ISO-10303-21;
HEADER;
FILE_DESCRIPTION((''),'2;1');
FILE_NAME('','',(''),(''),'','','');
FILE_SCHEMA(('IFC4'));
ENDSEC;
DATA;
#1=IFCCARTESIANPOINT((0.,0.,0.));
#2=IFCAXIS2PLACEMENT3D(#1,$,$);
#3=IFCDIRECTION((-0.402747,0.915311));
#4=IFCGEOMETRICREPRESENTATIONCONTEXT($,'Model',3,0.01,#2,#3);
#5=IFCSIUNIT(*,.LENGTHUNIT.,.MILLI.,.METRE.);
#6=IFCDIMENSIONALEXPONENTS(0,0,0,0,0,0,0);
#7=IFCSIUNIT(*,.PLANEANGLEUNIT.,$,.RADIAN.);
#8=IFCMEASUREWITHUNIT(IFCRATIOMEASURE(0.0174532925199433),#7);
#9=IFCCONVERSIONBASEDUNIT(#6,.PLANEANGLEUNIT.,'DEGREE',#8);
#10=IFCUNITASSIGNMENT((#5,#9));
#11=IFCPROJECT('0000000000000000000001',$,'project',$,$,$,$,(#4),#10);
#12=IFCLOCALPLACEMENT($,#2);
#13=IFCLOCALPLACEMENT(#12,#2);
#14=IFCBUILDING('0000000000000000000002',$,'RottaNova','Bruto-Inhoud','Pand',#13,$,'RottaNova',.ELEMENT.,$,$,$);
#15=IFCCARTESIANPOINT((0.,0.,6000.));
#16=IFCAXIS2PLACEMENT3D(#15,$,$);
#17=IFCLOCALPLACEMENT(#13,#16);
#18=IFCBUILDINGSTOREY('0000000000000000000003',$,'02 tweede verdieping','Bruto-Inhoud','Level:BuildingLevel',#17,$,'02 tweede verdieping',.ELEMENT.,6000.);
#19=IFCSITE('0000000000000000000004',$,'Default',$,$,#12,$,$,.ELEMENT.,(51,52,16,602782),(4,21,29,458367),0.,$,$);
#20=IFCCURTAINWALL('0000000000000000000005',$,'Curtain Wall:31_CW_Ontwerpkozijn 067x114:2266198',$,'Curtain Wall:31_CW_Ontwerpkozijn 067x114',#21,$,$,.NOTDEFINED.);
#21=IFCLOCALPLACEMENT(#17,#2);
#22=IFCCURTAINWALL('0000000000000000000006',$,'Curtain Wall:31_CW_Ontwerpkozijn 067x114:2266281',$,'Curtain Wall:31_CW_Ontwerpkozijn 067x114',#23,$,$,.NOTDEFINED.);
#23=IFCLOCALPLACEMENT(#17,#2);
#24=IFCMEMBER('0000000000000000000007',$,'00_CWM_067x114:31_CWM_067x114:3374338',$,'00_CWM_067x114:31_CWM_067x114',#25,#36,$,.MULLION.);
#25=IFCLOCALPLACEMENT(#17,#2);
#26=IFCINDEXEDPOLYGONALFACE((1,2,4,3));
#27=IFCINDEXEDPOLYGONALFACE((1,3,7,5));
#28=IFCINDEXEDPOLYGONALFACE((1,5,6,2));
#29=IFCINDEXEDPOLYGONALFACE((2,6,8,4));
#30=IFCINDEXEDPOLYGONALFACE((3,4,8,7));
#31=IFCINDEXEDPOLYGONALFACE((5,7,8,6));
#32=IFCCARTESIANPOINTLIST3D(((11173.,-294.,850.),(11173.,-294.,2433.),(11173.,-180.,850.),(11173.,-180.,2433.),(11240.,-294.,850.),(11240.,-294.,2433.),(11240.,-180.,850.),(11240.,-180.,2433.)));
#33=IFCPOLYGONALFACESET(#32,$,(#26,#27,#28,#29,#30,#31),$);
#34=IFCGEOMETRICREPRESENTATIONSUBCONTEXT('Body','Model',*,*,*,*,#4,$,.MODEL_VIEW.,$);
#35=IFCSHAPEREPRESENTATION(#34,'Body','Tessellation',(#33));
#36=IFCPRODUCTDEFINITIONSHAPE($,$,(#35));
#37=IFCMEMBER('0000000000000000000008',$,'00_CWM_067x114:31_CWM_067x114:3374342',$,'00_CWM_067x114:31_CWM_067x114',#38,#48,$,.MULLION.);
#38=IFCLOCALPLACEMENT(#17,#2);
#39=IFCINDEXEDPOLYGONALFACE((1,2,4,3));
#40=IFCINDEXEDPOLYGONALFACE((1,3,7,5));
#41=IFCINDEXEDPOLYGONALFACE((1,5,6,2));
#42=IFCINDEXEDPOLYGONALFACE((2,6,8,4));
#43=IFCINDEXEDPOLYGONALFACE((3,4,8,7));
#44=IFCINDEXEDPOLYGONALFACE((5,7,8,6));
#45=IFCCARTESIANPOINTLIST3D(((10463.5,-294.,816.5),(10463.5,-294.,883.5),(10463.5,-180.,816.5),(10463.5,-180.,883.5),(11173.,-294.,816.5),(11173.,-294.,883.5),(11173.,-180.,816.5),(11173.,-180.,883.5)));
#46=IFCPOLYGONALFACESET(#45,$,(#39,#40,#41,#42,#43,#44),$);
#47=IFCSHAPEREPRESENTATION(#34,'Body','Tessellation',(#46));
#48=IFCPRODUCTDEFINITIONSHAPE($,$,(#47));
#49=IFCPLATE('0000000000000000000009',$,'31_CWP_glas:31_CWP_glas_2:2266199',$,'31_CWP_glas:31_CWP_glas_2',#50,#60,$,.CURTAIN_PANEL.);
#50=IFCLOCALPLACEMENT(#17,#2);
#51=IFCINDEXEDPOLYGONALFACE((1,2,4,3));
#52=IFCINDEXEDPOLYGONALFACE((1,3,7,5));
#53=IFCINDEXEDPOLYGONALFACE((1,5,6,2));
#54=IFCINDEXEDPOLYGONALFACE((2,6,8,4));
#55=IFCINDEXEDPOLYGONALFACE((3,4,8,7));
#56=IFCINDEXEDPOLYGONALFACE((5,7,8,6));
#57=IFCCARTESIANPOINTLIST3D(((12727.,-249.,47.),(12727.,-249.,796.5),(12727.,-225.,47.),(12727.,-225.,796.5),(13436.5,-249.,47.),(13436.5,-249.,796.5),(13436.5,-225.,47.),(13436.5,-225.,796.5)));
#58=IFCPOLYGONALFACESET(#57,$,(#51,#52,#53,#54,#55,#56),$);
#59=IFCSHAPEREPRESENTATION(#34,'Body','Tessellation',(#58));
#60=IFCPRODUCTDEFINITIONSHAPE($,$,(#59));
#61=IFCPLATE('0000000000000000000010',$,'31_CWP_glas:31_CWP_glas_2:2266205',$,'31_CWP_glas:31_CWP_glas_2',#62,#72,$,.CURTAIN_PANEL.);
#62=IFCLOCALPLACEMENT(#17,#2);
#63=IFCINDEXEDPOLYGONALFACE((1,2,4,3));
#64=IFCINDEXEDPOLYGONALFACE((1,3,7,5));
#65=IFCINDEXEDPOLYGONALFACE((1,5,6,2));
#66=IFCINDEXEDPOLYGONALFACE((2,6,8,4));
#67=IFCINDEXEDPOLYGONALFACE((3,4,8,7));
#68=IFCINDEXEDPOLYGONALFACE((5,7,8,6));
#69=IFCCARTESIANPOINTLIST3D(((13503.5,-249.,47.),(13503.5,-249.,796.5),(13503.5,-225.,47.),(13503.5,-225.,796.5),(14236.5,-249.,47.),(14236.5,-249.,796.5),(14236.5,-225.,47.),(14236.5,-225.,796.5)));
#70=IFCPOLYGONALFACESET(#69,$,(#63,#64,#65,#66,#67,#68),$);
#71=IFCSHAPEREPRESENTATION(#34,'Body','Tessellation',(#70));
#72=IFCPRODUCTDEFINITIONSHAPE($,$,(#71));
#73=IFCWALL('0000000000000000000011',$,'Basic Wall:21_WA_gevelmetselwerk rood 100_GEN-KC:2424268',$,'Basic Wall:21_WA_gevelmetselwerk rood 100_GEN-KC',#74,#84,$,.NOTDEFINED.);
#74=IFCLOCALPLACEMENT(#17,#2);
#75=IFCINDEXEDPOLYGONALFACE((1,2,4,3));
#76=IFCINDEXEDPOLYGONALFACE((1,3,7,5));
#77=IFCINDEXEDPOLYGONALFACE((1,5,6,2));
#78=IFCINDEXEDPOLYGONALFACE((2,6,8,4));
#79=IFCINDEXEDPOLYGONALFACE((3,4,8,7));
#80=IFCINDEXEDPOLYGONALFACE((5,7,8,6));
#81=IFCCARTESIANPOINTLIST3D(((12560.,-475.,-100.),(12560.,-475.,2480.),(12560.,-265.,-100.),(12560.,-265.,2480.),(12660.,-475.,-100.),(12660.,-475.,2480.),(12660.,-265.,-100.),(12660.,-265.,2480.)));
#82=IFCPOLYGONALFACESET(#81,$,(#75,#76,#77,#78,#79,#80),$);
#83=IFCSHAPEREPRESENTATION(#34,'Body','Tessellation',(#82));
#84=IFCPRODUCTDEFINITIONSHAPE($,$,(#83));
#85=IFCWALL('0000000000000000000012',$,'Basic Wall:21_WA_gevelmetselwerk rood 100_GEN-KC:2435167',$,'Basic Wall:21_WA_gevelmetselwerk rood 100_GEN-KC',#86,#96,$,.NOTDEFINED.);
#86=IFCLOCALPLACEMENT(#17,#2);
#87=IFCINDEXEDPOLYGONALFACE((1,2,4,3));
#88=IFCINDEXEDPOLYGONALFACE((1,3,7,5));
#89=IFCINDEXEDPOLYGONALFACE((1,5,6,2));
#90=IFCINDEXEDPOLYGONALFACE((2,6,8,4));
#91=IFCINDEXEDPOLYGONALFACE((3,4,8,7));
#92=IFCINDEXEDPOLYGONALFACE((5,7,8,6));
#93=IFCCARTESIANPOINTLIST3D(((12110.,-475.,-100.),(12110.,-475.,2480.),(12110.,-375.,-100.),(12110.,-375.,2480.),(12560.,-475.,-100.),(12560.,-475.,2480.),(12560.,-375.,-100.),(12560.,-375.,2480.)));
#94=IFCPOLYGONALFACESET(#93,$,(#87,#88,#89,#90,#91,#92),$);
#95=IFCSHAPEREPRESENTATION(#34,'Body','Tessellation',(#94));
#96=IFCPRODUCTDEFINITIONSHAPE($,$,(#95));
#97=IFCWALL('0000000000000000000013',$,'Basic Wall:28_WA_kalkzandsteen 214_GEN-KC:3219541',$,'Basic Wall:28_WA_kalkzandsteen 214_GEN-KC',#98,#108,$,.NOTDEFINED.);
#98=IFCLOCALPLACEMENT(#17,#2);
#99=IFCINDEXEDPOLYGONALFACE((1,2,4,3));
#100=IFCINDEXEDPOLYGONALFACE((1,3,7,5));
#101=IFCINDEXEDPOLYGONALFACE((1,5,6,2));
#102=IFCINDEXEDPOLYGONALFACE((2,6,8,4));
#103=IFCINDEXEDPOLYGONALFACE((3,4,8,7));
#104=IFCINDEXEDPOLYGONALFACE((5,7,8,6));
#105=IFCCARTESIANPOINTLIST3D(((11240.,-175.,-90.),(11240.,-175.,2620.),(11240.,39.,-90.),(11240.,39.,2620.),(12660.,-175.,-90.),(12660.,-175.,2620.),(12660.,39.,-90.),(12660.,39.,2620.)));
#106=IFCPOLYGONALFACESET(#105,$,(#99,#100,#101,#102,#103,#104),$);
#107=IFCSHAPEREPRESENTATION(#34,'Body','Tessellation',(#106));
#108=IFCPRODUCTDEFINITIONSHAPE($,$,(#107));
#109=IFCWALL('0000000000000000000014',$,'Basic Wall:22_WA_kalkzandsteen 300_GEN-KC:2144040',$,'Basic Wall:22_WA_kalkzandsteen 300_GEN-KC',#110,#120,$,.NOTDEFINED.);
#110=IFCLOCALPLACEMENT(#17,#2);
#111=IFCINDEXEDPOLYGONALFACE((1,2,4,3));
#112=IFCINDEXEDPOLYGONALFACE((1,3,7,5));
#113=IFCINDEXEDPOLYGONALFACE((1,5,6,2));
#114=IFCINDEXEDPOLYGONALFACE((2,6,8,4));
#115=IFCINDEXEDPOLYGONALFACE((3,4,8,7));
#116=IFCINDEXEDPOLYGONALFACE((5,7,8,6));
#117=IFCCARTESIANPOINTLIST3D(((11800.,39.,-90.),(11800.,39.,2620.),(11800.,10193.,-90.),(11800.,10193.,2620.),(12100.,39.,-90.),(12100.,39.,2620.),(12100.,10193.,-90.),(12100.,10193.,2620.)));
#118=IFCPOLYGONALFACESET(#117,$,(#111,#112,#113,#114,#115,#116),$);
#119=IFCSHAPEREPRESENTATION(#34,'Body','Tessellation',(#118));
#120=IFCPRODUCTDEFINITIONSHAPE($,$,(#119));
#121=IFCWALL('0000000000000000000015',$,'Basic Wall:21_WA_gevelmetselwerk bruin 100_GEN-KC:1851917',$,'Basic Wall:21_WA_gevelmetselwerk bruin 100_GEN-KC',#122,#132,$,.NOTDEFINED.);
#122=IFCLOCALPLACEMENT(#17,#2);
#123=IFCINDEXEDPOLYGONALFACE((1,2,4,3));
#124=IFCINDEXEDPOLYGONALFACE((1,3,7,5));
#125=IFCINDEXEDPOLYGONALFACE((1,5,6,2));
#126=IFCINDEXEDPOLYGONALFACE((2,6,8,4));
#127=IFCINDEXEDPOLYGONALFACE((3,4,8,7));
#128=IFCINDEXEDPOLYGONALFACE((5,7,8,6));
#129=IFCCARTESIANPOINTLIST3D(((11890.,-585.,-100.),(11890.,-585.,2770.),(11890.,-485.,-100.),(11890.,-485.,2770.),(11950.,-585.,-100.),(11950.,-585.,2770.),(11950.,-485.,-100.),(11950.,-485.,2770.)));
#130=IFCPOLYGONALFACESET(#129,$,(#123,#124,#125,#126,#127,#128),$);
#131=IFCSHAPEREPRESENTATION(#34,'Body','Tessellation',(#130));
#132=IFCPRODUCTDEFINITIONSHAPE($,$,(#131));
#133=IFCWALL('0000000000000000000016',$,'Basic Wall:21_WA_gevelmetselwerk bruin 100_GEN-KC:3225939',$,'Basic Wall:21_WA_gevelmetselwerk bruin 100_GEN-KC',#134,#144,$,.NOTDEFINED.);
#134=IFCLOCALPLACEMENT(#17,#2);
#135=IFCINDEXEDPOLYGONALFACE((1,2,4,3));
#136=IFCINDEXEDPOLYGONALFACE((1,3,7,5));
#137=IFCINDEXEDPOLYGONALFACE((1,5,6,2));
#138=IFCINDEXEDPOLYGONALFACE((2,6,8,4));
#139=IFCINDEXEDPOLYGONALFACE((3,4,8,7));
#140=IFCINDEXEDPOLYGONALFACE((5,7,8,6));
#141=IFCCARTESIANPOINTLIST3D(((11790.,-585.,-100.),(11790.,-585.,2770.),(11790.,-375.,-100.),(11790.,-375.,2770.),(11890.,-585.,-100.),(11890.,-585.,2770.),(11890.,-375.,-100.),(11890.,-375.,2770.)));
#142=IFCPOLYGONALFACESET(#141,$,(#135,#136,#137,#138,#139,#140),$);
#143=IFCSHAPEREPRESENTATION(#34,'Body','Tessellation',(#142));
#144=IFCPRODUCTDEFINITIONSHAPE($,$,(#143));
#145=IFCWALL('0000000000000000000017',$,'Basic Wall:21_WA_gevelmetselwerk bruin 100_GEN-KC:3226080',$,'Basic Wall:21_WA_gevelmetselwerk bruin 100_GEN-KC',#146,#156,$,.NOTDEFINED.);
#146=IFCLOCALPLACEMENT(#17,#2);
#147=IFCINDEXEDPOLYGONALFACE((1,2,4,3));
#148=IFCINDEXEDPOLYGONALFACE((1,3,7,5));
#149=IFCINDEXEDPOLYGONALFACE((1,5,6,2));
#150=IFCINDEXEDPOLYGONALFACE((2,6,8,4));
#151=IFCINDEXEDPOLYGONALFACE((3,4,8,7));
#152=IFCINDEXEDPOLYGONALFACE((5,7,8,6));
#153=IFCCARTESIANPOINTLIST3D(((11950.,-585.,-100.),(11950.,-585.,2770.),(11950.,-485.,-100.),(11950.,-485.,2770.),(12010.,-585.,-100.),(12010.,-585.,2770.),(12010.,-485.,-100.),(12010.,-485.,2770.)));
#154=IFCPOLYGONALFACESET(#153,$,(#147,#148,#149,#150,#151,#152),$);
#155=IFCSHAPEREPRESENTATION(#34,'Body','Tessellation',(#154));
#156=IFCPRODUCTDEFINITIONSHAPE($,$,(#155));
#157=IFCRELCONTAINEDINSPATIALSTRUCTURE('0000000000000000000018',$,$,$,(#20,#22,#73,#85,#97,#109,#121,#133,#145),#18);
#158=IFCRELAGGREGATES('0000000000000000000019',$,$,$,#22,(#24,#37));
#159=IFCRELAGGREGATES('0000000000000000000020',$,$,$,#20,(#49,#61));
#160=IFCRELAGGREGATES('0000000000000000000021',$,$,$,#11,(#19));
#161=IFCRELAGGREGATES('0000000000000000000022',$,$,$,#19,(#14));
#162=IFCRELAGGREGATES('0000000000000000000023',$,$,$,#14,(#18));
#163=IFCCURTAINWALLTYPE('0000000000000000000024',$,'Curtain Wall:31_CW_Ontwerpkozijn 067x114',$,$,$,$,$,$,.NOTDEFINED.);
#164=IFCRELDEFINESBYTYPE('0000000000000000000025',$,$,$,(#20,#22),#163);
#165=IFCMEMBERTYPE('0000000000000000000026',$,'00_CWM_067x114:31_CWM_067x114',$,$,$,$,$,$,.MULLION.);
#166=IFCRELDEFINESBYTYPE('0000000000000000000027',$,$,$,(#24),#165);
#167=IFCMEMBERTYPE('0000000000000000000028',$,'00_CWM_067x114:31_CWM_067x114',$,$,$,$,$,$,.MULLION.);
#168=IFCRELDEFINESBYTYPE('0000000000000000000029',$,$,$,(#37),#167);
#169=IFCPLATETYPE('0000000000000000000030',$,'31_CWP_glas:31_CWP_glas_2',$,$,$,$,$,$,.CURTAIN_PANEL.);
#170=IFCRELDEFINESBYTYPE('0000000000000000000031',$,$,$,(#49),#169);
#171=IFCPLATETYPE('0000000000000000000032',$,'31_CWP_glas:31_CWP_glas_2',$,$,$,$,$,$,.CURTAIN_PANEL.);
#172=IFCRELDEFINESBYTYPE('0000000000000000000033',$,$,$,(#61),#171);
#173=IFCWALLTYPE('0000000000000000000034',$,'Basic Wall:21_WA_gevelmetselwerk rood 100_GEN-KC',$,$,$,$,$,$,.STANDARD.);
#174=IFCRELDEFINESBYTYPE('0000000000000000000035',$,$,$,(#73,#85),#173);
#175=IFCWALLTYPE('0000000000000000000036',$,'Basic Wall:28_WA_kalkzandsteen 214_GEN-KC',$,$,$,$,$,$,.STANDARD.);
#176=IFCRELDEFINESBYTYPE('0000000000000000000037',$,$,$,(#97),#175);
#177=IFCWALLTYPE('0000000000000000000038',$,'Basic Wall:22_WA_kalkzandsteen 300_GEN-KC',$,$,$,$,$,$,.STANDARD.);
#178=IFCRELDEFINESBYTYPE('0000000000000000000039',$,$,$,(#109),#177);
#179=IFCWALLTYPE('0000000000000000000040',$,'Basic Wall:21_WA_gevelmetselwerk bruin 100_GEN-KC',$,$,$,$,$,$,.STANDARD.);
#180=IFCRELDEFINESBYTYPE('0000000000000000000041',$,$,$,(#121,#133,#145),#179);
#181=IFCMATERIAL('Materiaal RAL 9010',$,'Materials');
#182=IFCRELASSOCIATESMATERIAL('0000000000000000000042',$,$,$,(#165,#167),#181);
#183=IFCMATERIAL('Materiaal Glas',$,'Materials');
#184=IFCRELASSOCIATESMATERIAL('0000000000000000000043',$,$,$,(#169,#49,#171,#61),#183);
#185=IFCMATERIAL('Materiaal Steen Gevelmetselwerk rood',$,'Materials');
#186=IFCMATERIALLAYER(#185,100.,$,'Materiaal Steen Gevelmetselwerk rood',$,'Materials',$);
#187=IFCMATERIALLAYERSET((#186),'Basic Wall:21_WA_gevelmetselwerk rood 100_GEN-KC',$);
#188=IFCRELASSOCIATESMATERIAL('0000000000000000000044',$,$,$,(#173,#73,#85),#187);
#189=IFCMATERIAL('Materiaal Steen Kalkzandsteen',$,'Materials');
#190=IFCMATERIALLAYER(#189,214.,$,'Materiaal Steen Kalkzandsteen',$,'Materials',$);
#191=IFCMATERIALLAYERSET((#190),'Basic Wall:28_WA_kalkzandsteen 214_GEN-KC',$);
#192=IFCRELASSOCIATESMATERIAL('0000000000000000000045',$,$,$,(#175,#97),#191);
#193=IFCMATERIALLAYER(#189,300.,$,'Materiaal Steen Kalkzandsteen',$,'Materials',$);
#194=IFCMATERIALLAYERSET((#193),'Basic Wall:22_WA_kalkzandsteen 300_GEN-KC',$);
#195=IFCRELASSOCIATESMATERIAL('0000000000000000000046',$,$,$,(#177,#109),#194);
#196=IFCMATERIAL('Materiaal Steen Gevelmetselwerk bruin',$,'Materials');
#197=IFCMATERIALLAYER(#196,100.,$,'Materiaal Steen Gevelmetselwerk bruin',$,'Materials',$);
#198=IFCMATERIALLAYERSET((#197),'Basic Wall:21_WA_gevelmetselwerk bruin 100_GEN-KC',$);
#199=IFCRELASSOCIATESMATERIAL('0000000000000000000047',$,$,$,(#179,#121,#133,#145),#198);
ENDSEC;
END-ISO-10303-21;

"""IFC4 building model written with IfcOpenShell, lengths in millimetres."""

from ifc_helpers import new_model, entity, si_unit, converted_unit, direction, frame, frame_2d, origin, origin_2d_with_axis, place, context, subcontext, project, spatial, rectangle, extrude, source, transform, mapped, material, layer, layer_set, material_profile, profile_set, type_object, type_shapes, element, aggregate, save


model = new_model("IFC4")

# Units and contexts
model_context = context("Model", 3, precision=0.01, world=origin(), true_north=direction((-0.402747, 0.915311)))
body_context = subcontext(model_context, "Body", "Model", "MODEL_VIEW")
ifc_project = project(units=[si_unit("LENGTHUNIT", "METRE", prefix="MILLI"), converted_unit("PLANEANGLEUNIT", "DEGREE", entity("IfcRatioMeasure", 0.0174532925199433), si_unit("PLANEANGLEUNIT", "RADIAN"), dimensions=[0, 0, 0, 0, 0, 0, 0])], contexts=[model_context])

# Site, building, storey
site_placement = place(None, origin())
site = spatial("IfcSite", under=ifc_project, at=site_placement, Name="Default", CompositionType="ELEMENT", RefLatitude=(51, 52, 16, 602782), RefLongitude=(4, 21, 29, 458367), RefElevation=0.0)
building_placement = place(site_placement, origin())
building = spatial("IfcBuilding", under=site, at=building_placement, Name="RottaNova", Description="Bruto-Inhoud", ObjectType="Pand", LongName="RottaNova", CompositionType="ELEMENT")
storey_placement = place(building_placement, frame((0.0, 0.0, 6000.0)))
storey = spatial("IfcBuildingStorey", under=building, at=storey_placement, Name="02 tweede verdieping", Description="Bruto-Inhoud", ObjectType="Level:BuildingLevel", LongName="02 tweede verdieping", CompositionType="ELEMENT", Elevation=6000.0)

# Curtain walls, members
curtain_wall_type = type_object("IfcCurtainWallType", Name="Curtain Wall:31_CW_Ontwerpkozijn 067x114", PredefinedType="NOTDEFINED")
curtain_wall_1_placement = place(storey_placement, frame((0.0, 0.0, -6000.0)))
curtain_wall_1 = element("IfcCurtainWall", 1, at=curtain_wall_1_placement, inside=storey, type_object=curtain_wall_type, Name="Curtain Wall:31_CW_Ontwerpkozijn 067x114:2266198", ObjectType="Curtain Wall:31_CW_Ontwerpkozijn 067x114", PredefinedType="NOTDEFINED")
curtain_wall_2_placement = place(storey_placement, frame((0.0, 0.0, -6000.0)))
curtain_wall_2 = element("IfcCurtainWall", 2, at=curtain_wall_2_placement, inside=storey, type_object=curtain_wall_type, Name="Curtain Wall:31_CW_Ontwerpkozijn 067x114:2266281", ObjectType="Curtain Wall:31_CW_Ontwerpkozijn 067x114", PredefinedType="NOTDEFINED")
ifc_material_1 = material(Name="Materiaal RAL 9010", Category="Materials")
ifc_material_profile_1 = material_profile(ifc_material_1, rectangle(XDim=114.0, YDim=67.0, at=origin_2d_with_axis()), Name="31_CWM_067x114")
ifc_profile_set_1 = profile_set([ifc_material_profile_1], Name="31_CWM_067x114")
member_type_1 = type_object("IfcMemberType", Name="00_CWM_067x114:31_CWM_067x114", PredefinedType="MULLION", material=ifc_profile_set_1)
shared_shape_1 = source(origin(), body_context, "Body", "SweptSolid", [
    extrude(rectangle(XDim=114.0, YDim=67.0, at=origin_2d_with_axis()), frame((-33.5, 57.0, -1583.0), z_axis=(0.0, 0.0, 1.0), x_axis=(0.0, -1.0, 0.0)), (0.0, 0.0, 1.0), 1583.0),
])
type_shapes(member_type_1, [shared_shape_1])
member_1_placement = place(curtain_wall_2_placement, frame((11240.0, -180.0, 6850.0), z_axis=(0.0, 0.0, -1.0), x_axis=(1.0, 0.0, 0.0)))
member_1 = element("IfcMember", 3, at=member_1_placement, type_object=member_type_1, Name="00_CWM_067x114:31_CWM_067x114:3374338", ObjectType="00_CWM_067x114:31_CWM_067x114", PredefinedType="MULLION", context=body_context, shape_type="MappedRepresentation", body=[
    mapped(shared_shape_1, transform((0.0, 0.0, 0.0), scale=1.0)),
])
member_type_2 = type_object("IfcMemberType", Name="00_CWM_067x114:31_CWM_067x114", PredefinedType="MULLION", material=ifc_profile_set_1)
shared_shape_2 = source(origin(), body_context, "Body", "SweptSolid", [
    extrude(rectangle(XDim=114.0, YDim=67.0, at=origin_2d_with_axis()), frame((0.0, 57.0, -709.5), z_axis=(0.0, 0.0, 1.0), x_axis=(0.0, -1.0, 0.0)), (0.0, 0.0, 1.0), 709.5),
])
type_shapes(member_type_2, [shared_shape_2])
member_2_placement = place(curtain_wall_2_placement, frame((11173.0, -180.0, 6850.0), z_axis=(1.0, 0.0, 0.0), x_axis=(0.0, 0.0, 1.0)))
member_2 = element("IfcMember", 4, at=member_2_placement, type_object=member_type_2, Name="00_CWM_067x114:31_CWM_067x114:3374342", ObjectType="00_CWM_067x114:31_CWM_067x114", PredefinedType="MULLION", context=body_context, shape_type="MappedRepresentation", body=[
    mapped(shared_shape_2, transform((0.0, 0.0, 0.0), scale=1.0)),
])
aggregate(curtain_wall_2, [member_1, member_2])

# Plates
ifc_material_2 = material(Name="Materiaal Glas", Category="Materials")
plate_type_1 = type_object("IfcPlateType", Name="31_CWP_glas:31_CWP_glas_2", PredefinedType="CURTAIN_PANEL", material=ifc_material_2)
shared_shape_3 = source(origin(), body_context, "Body", "SweptSolid", [
    extrude(rectangle(XDim=24.0, YDim=709.5, at=frame_2d((0.0, 0.0), x_axis=(1.0, 0.0))), frame((354.8, 12.0, 0.0), z_axis=(0.0, 0.0, 1.0), x_axis=(0.0, 1.0, 0.0)), (0.0, 0.0, 1.0), 749.5),
])
type_shapes(plate_type_1, [shared_shape_3])
plate_1_placement = place(curtain_wall_1_placement, frame((12727.0, -249.0, 6047.0)))
plate_1 = element("IfcPlate", 5, at=plate_1_placement, type_object=plate_type_1, material=ifc_material_2, Name="31_CWP_glas:31_CWP_glas_2:2266199", ObjectType="31_CWP_glas:31_CWP_glas_2", PredefinedType="CURTAIN_PANEL", context=body_context, shape_type="MappedRepresentation", body=[
    mapped(shared_shape_3, transform((0.0, 0.0, 0.0), scale=1.0)),
])
plate_type_2 = type_object("IfcPlateType", Name="31_CWP_glas:31_CWP_glas_2", PredefinedType="CURTAIN_PANEL", material=ifc_material_2)
shared_shape_4 = source(origin(), body_context, "Body", "SweptSolid", [
    extrude(rectangle(XDim=24.0, YDim=733.0, at=frame_2d((0.0, 0.0), x_axis=(1.0, 0.0))), frame((366.5, 12.0, 0.0), z_axis=(0.0, 0.0, 1.0), x_axis=(0.0, 1.0, 0.0)), (0.0, 0.0, 1.0), 749.5),
])
type_shapes(plate_type_2, [shared_shape_4])
plate_2_placement = place(curtain_wall_1_placement, frame((13503.5, -249.0, 6047.0)))
plate_2 = element("IfcPlate", 6, at=plate_2_placement, type_object=plate_type_2, material=ifc_material_2, Name="31_CWP_glas:31_CWP_glas_2:2266205", ObjectType="31_CWP_glas:31_CWP_glas_2", PredefinedType="CURTAIN_PANEL", context=body_context, shape_type="MappedRepresentation", body=[
    mapped(shared_shape_4, transform((0.0, 0.0, 0.0), scale=1.0)),
])

# Walls
ifc_material_3 = material(Name="Materiaal Steen Gevelmetselwerk rood", Category="Materials")
ifc_layer_1 = layer(ifc_material_3, 100.0, Name="Materiaal Steen Gevelmetselwerk rood", Category="Materials")
ifc_layer_set_1 = layer_set([ifc_layer_1], Name="Basic Wall:21_WA_gevelmetselwerk rood 100_GEN-KC")
wall_type_1 = type_object("IfcWallType", Name="Basic Wall:21_WA_gevelmetselwerk rood 100_GEN-KC", PredefinedType="STANDARD", material=ifc_layer_set_1)
wall_1_placement = place(storey_placement, frame((12610.0, -265.0, -100.0), z_axis=(0.0, 0.0, 1.0), x_axis=(0.0, -1.0, 0.0)))
element("IfcWall", 7, at=wall_1_placement, inside=storey, type_object=wall_type_1, material=ifc_layer_set_1, Name="Basic Wall:21_WA_gevelmetselwerk rood 100_GEN-KC:2424268", ObjectType="Basic Wall:21_WA_gevelmetselwerk rood 100_GEN-KC", PredefinedType="NOTDEFINED", context=body_context, shape_type="SweptSolid", body=[
    extrude(rectangle(XDim=210.0, YDim=100.0, at=frame_2d((105.0, 0.0), x_axis=(-1.0, 0.0))), origin(), (0.0, 0.0, 1.0), 2580.0),
])
wall_2_placement = place(storey_placement, frame((12560.0, -425.0, -100.0), z_axis=(0.0, 0.0, 1.0), x_axis=(-1.0, 0.0, 0.0)))
element("IfcWall", 8, at=wall_2_placement, inside=storey, type_object=wall_type_1, material=ifc_layer_set_1, Name="Basic Wall:21_WA_gevelmetselwerk rood 100_GEN-KC:2435167", ObjectType="Basic Wall:21_WA_gevelmetselwerk rood 100_GEN-KC", PredefinedType="NOTDEFINED", context=body_context, shape_type="SweptSolid", body=[
    extrude(rectangle(XDim=450.0, YDim=100.0, at=frame_2d((225.0, 0.0), x_axis=(-1.0, 0.0))), origin(), (0.0, 0.0, 1.0), 2580.0),
])
ifc_material_4 = material(Name="Materiaal Steen Kalkzandsteen", Category="Materials")
ifc_layer_2 = layer(ifc_material_4, 214.0, Name="Materiaal Steen Kalkzandsteen", Category="Materials")
ifc_layer_set_2 = layer_set([ifc_layer_2], Name="Basic Wall:28_WA_kalkzandsteen 214_GEN-KC")
wall_type_2 = type_object("IfcWallType", Name="Basic Wall:28_WA_kalkzandsteen 214_GEN-KC", PredefinedType="STANDARD", material=ifc_layer_set_2)
wall_3_placement = place(storey_placement, frame((12660.0, -68.0, -90.0), z_axis=(0.0, 0.0, 1.0), x_axis=(-1.0, 0.0, 0.0)))
element("IfcWall", 9, at=wall_3_placement, inside=storey, type_object=wall_type_2, material=ifc_layer_set_2, Name="Basic Wall:28_WA_kalkzandsteen 214_GEN-KC:3219541", ObjectType="Basic Wall:28_WA_kalkzandsteen 214_GEN-KC", PredefinedType="NOTDEFINED", context=body_context, shape_type="SweptSolid", body=[
    extrude(rectangle(XDim=1420.0, YDim=214.0, at=frame_2d((710.0, 0.0), x_axis=(-1.0, 0.0))), origin(), (0.0, 0.0, 1.0), 2710.0),
])
ifc_layer_3 = layer(ifc_material_4, 300.0, Name="Materiaal Steen Kalkzandsteen", Category="Materials")
ifc_layer_set_3 = layer_set([ifc_layer_3], Name="Basic Wall:22_WA_kalkzandsteen 300_GEN-KC")
wall_type_3 = type_object("IfcWallType", Name="Basic Wall:22_WA_kalkzandsteen 300_GEN-KC", PredefinedType="STANDARD", material=ifc_layer_set_3)
wall_4_placement = place(storey_placement, frame((11950.0, 39.0, -90.0), z_axis=(0.0, 0.0, 1.0), x_axis=(0.0, 1.0, 0.0)))
element("IfcWall", 10, at=wall_4_placement, inside=storey, type_object=wall_type_3, material=ifc_layer_set_3, Name="Basic Wall:22_WA_kalkzandsteen 300_GEN-KC:2144040", ObjectType="Basic Wall:22_WA_kalkzandsteen 300_GEN-KC", PredefinedType="NOTDEFINED", context=body_context, shape_type="SweptSolid", body=[
    extrude(rectangle(XDim=10154.0, YDim=300.0, at=frame_2d((5077.0, 0.0), x_axis=(-1.0, 0.0))), origin(), (0.0, 0.0, 1.0), 2710.0),
])
ifc_material_5 = material(Name="Materiaal Steen Gevelmetselwerk bruin", Category="Materials")
ifc_layer_4 = layer(ifc_material_5, 100.0, Name="Materiaal Steen Gevelmetselwerk bruin", Category="Materials")
ifc_layer_set_4 = layer_set([ifc_layer_4], Name="Basic Wall:21_WA_gevelmetselwerk bruin 100_GEN-KC")
wall_type_4 = type_object("IfcWallType", Name="Basic Wall:21_WA_gevelmetselwerk bruin 100_GEN-KC", PredefinedType="STANDARD", material=ifc_layer_set_4)
wall_5_placement = place(storey_placement, frame((11890.0, -535.0, -100.0)))
element("IfcWall", 11, at=wall_5_placement, inside=storey, type_object=wall_type_4, material=ifc_layer_set_4, Name="Basic Wall:21_WA_gevelmetselwerk bruin 100_GEN-KC:1851917", ObjectType="Basic Wall:21_WA_gevelmetselwerk bruin 100_GEN-KC", PredefinedType="NOTDEFINED", context=body_context, shape_type="SweptSolid", body=[
    extrude(rectangle(XDim=60.0, YDim=100.0, at=frame_2d((30.0, 0.0), x_axis=(-1.0, 0.0))), origin(), (0.0, 0.0, 1.0), 2870.0),
])
wall_6_placement = place(storey_placement, frame((11840.0, -585.0, -100.0), z_axis=(0.0, 0.0, 1.0), x_axis=(0.0, 1.0, 0.0)))
element("IfcWall", 12, at=wall_6_placement, inside=storey, type_object=wall_type_4, material=ifc_layer_set_4, Name="Basic Wall:21_WA_gevelmetselwerk bruin 100_GEN-KC:3225939", ObjectType="Basic Wall:21_WA_gevelmetselwerk bruin 100_GEN-KC", PredefinedType="NOTDEFINED", context=body_context, shape_type="SweptSolid", body=[
    extrude(rectangle(XDim=210.0, YDim=100.0, at=frame_2d((105.0, 0.0), x_axis=(-1.0, 0.0))), origin(), (0.0, 0.0, 1.0), 2870.0),
])
wall_7_placement = place(storey_placement, frame((12010.0, -535.0, -100.0), z_axis=(0.0, 0.0, 1.0), x_axis=(-1.0, 0.0, 0.0)))
element("IfcWall", 13, at=wall_7_placement, inside=storey, type_object=wall_type_4, material=ifc_layer_set_4, Name="Basic Wall:21_WA_gevelmetselwerk bruin 100_GEN-KC:3226080", ObjectType="Basic Wall:21_WA_gevelmetselwerk bruin 100_GEN-KC", PredefinedType="NOTDEFINED", context=body_context, shape_type="SweptSolid", body=[
    extrude(rectangle(XDim=60.0, YDim=100.0, at=frame_2d((30.0, 0.0), x_axis=(-1.0, 0.0))), origin(), (0.0, 0.0, 1.0), 2870.0),
])

aggregate(curtain_wall_1, [plate_1, plate_2])

save(model, "model.ifc")
